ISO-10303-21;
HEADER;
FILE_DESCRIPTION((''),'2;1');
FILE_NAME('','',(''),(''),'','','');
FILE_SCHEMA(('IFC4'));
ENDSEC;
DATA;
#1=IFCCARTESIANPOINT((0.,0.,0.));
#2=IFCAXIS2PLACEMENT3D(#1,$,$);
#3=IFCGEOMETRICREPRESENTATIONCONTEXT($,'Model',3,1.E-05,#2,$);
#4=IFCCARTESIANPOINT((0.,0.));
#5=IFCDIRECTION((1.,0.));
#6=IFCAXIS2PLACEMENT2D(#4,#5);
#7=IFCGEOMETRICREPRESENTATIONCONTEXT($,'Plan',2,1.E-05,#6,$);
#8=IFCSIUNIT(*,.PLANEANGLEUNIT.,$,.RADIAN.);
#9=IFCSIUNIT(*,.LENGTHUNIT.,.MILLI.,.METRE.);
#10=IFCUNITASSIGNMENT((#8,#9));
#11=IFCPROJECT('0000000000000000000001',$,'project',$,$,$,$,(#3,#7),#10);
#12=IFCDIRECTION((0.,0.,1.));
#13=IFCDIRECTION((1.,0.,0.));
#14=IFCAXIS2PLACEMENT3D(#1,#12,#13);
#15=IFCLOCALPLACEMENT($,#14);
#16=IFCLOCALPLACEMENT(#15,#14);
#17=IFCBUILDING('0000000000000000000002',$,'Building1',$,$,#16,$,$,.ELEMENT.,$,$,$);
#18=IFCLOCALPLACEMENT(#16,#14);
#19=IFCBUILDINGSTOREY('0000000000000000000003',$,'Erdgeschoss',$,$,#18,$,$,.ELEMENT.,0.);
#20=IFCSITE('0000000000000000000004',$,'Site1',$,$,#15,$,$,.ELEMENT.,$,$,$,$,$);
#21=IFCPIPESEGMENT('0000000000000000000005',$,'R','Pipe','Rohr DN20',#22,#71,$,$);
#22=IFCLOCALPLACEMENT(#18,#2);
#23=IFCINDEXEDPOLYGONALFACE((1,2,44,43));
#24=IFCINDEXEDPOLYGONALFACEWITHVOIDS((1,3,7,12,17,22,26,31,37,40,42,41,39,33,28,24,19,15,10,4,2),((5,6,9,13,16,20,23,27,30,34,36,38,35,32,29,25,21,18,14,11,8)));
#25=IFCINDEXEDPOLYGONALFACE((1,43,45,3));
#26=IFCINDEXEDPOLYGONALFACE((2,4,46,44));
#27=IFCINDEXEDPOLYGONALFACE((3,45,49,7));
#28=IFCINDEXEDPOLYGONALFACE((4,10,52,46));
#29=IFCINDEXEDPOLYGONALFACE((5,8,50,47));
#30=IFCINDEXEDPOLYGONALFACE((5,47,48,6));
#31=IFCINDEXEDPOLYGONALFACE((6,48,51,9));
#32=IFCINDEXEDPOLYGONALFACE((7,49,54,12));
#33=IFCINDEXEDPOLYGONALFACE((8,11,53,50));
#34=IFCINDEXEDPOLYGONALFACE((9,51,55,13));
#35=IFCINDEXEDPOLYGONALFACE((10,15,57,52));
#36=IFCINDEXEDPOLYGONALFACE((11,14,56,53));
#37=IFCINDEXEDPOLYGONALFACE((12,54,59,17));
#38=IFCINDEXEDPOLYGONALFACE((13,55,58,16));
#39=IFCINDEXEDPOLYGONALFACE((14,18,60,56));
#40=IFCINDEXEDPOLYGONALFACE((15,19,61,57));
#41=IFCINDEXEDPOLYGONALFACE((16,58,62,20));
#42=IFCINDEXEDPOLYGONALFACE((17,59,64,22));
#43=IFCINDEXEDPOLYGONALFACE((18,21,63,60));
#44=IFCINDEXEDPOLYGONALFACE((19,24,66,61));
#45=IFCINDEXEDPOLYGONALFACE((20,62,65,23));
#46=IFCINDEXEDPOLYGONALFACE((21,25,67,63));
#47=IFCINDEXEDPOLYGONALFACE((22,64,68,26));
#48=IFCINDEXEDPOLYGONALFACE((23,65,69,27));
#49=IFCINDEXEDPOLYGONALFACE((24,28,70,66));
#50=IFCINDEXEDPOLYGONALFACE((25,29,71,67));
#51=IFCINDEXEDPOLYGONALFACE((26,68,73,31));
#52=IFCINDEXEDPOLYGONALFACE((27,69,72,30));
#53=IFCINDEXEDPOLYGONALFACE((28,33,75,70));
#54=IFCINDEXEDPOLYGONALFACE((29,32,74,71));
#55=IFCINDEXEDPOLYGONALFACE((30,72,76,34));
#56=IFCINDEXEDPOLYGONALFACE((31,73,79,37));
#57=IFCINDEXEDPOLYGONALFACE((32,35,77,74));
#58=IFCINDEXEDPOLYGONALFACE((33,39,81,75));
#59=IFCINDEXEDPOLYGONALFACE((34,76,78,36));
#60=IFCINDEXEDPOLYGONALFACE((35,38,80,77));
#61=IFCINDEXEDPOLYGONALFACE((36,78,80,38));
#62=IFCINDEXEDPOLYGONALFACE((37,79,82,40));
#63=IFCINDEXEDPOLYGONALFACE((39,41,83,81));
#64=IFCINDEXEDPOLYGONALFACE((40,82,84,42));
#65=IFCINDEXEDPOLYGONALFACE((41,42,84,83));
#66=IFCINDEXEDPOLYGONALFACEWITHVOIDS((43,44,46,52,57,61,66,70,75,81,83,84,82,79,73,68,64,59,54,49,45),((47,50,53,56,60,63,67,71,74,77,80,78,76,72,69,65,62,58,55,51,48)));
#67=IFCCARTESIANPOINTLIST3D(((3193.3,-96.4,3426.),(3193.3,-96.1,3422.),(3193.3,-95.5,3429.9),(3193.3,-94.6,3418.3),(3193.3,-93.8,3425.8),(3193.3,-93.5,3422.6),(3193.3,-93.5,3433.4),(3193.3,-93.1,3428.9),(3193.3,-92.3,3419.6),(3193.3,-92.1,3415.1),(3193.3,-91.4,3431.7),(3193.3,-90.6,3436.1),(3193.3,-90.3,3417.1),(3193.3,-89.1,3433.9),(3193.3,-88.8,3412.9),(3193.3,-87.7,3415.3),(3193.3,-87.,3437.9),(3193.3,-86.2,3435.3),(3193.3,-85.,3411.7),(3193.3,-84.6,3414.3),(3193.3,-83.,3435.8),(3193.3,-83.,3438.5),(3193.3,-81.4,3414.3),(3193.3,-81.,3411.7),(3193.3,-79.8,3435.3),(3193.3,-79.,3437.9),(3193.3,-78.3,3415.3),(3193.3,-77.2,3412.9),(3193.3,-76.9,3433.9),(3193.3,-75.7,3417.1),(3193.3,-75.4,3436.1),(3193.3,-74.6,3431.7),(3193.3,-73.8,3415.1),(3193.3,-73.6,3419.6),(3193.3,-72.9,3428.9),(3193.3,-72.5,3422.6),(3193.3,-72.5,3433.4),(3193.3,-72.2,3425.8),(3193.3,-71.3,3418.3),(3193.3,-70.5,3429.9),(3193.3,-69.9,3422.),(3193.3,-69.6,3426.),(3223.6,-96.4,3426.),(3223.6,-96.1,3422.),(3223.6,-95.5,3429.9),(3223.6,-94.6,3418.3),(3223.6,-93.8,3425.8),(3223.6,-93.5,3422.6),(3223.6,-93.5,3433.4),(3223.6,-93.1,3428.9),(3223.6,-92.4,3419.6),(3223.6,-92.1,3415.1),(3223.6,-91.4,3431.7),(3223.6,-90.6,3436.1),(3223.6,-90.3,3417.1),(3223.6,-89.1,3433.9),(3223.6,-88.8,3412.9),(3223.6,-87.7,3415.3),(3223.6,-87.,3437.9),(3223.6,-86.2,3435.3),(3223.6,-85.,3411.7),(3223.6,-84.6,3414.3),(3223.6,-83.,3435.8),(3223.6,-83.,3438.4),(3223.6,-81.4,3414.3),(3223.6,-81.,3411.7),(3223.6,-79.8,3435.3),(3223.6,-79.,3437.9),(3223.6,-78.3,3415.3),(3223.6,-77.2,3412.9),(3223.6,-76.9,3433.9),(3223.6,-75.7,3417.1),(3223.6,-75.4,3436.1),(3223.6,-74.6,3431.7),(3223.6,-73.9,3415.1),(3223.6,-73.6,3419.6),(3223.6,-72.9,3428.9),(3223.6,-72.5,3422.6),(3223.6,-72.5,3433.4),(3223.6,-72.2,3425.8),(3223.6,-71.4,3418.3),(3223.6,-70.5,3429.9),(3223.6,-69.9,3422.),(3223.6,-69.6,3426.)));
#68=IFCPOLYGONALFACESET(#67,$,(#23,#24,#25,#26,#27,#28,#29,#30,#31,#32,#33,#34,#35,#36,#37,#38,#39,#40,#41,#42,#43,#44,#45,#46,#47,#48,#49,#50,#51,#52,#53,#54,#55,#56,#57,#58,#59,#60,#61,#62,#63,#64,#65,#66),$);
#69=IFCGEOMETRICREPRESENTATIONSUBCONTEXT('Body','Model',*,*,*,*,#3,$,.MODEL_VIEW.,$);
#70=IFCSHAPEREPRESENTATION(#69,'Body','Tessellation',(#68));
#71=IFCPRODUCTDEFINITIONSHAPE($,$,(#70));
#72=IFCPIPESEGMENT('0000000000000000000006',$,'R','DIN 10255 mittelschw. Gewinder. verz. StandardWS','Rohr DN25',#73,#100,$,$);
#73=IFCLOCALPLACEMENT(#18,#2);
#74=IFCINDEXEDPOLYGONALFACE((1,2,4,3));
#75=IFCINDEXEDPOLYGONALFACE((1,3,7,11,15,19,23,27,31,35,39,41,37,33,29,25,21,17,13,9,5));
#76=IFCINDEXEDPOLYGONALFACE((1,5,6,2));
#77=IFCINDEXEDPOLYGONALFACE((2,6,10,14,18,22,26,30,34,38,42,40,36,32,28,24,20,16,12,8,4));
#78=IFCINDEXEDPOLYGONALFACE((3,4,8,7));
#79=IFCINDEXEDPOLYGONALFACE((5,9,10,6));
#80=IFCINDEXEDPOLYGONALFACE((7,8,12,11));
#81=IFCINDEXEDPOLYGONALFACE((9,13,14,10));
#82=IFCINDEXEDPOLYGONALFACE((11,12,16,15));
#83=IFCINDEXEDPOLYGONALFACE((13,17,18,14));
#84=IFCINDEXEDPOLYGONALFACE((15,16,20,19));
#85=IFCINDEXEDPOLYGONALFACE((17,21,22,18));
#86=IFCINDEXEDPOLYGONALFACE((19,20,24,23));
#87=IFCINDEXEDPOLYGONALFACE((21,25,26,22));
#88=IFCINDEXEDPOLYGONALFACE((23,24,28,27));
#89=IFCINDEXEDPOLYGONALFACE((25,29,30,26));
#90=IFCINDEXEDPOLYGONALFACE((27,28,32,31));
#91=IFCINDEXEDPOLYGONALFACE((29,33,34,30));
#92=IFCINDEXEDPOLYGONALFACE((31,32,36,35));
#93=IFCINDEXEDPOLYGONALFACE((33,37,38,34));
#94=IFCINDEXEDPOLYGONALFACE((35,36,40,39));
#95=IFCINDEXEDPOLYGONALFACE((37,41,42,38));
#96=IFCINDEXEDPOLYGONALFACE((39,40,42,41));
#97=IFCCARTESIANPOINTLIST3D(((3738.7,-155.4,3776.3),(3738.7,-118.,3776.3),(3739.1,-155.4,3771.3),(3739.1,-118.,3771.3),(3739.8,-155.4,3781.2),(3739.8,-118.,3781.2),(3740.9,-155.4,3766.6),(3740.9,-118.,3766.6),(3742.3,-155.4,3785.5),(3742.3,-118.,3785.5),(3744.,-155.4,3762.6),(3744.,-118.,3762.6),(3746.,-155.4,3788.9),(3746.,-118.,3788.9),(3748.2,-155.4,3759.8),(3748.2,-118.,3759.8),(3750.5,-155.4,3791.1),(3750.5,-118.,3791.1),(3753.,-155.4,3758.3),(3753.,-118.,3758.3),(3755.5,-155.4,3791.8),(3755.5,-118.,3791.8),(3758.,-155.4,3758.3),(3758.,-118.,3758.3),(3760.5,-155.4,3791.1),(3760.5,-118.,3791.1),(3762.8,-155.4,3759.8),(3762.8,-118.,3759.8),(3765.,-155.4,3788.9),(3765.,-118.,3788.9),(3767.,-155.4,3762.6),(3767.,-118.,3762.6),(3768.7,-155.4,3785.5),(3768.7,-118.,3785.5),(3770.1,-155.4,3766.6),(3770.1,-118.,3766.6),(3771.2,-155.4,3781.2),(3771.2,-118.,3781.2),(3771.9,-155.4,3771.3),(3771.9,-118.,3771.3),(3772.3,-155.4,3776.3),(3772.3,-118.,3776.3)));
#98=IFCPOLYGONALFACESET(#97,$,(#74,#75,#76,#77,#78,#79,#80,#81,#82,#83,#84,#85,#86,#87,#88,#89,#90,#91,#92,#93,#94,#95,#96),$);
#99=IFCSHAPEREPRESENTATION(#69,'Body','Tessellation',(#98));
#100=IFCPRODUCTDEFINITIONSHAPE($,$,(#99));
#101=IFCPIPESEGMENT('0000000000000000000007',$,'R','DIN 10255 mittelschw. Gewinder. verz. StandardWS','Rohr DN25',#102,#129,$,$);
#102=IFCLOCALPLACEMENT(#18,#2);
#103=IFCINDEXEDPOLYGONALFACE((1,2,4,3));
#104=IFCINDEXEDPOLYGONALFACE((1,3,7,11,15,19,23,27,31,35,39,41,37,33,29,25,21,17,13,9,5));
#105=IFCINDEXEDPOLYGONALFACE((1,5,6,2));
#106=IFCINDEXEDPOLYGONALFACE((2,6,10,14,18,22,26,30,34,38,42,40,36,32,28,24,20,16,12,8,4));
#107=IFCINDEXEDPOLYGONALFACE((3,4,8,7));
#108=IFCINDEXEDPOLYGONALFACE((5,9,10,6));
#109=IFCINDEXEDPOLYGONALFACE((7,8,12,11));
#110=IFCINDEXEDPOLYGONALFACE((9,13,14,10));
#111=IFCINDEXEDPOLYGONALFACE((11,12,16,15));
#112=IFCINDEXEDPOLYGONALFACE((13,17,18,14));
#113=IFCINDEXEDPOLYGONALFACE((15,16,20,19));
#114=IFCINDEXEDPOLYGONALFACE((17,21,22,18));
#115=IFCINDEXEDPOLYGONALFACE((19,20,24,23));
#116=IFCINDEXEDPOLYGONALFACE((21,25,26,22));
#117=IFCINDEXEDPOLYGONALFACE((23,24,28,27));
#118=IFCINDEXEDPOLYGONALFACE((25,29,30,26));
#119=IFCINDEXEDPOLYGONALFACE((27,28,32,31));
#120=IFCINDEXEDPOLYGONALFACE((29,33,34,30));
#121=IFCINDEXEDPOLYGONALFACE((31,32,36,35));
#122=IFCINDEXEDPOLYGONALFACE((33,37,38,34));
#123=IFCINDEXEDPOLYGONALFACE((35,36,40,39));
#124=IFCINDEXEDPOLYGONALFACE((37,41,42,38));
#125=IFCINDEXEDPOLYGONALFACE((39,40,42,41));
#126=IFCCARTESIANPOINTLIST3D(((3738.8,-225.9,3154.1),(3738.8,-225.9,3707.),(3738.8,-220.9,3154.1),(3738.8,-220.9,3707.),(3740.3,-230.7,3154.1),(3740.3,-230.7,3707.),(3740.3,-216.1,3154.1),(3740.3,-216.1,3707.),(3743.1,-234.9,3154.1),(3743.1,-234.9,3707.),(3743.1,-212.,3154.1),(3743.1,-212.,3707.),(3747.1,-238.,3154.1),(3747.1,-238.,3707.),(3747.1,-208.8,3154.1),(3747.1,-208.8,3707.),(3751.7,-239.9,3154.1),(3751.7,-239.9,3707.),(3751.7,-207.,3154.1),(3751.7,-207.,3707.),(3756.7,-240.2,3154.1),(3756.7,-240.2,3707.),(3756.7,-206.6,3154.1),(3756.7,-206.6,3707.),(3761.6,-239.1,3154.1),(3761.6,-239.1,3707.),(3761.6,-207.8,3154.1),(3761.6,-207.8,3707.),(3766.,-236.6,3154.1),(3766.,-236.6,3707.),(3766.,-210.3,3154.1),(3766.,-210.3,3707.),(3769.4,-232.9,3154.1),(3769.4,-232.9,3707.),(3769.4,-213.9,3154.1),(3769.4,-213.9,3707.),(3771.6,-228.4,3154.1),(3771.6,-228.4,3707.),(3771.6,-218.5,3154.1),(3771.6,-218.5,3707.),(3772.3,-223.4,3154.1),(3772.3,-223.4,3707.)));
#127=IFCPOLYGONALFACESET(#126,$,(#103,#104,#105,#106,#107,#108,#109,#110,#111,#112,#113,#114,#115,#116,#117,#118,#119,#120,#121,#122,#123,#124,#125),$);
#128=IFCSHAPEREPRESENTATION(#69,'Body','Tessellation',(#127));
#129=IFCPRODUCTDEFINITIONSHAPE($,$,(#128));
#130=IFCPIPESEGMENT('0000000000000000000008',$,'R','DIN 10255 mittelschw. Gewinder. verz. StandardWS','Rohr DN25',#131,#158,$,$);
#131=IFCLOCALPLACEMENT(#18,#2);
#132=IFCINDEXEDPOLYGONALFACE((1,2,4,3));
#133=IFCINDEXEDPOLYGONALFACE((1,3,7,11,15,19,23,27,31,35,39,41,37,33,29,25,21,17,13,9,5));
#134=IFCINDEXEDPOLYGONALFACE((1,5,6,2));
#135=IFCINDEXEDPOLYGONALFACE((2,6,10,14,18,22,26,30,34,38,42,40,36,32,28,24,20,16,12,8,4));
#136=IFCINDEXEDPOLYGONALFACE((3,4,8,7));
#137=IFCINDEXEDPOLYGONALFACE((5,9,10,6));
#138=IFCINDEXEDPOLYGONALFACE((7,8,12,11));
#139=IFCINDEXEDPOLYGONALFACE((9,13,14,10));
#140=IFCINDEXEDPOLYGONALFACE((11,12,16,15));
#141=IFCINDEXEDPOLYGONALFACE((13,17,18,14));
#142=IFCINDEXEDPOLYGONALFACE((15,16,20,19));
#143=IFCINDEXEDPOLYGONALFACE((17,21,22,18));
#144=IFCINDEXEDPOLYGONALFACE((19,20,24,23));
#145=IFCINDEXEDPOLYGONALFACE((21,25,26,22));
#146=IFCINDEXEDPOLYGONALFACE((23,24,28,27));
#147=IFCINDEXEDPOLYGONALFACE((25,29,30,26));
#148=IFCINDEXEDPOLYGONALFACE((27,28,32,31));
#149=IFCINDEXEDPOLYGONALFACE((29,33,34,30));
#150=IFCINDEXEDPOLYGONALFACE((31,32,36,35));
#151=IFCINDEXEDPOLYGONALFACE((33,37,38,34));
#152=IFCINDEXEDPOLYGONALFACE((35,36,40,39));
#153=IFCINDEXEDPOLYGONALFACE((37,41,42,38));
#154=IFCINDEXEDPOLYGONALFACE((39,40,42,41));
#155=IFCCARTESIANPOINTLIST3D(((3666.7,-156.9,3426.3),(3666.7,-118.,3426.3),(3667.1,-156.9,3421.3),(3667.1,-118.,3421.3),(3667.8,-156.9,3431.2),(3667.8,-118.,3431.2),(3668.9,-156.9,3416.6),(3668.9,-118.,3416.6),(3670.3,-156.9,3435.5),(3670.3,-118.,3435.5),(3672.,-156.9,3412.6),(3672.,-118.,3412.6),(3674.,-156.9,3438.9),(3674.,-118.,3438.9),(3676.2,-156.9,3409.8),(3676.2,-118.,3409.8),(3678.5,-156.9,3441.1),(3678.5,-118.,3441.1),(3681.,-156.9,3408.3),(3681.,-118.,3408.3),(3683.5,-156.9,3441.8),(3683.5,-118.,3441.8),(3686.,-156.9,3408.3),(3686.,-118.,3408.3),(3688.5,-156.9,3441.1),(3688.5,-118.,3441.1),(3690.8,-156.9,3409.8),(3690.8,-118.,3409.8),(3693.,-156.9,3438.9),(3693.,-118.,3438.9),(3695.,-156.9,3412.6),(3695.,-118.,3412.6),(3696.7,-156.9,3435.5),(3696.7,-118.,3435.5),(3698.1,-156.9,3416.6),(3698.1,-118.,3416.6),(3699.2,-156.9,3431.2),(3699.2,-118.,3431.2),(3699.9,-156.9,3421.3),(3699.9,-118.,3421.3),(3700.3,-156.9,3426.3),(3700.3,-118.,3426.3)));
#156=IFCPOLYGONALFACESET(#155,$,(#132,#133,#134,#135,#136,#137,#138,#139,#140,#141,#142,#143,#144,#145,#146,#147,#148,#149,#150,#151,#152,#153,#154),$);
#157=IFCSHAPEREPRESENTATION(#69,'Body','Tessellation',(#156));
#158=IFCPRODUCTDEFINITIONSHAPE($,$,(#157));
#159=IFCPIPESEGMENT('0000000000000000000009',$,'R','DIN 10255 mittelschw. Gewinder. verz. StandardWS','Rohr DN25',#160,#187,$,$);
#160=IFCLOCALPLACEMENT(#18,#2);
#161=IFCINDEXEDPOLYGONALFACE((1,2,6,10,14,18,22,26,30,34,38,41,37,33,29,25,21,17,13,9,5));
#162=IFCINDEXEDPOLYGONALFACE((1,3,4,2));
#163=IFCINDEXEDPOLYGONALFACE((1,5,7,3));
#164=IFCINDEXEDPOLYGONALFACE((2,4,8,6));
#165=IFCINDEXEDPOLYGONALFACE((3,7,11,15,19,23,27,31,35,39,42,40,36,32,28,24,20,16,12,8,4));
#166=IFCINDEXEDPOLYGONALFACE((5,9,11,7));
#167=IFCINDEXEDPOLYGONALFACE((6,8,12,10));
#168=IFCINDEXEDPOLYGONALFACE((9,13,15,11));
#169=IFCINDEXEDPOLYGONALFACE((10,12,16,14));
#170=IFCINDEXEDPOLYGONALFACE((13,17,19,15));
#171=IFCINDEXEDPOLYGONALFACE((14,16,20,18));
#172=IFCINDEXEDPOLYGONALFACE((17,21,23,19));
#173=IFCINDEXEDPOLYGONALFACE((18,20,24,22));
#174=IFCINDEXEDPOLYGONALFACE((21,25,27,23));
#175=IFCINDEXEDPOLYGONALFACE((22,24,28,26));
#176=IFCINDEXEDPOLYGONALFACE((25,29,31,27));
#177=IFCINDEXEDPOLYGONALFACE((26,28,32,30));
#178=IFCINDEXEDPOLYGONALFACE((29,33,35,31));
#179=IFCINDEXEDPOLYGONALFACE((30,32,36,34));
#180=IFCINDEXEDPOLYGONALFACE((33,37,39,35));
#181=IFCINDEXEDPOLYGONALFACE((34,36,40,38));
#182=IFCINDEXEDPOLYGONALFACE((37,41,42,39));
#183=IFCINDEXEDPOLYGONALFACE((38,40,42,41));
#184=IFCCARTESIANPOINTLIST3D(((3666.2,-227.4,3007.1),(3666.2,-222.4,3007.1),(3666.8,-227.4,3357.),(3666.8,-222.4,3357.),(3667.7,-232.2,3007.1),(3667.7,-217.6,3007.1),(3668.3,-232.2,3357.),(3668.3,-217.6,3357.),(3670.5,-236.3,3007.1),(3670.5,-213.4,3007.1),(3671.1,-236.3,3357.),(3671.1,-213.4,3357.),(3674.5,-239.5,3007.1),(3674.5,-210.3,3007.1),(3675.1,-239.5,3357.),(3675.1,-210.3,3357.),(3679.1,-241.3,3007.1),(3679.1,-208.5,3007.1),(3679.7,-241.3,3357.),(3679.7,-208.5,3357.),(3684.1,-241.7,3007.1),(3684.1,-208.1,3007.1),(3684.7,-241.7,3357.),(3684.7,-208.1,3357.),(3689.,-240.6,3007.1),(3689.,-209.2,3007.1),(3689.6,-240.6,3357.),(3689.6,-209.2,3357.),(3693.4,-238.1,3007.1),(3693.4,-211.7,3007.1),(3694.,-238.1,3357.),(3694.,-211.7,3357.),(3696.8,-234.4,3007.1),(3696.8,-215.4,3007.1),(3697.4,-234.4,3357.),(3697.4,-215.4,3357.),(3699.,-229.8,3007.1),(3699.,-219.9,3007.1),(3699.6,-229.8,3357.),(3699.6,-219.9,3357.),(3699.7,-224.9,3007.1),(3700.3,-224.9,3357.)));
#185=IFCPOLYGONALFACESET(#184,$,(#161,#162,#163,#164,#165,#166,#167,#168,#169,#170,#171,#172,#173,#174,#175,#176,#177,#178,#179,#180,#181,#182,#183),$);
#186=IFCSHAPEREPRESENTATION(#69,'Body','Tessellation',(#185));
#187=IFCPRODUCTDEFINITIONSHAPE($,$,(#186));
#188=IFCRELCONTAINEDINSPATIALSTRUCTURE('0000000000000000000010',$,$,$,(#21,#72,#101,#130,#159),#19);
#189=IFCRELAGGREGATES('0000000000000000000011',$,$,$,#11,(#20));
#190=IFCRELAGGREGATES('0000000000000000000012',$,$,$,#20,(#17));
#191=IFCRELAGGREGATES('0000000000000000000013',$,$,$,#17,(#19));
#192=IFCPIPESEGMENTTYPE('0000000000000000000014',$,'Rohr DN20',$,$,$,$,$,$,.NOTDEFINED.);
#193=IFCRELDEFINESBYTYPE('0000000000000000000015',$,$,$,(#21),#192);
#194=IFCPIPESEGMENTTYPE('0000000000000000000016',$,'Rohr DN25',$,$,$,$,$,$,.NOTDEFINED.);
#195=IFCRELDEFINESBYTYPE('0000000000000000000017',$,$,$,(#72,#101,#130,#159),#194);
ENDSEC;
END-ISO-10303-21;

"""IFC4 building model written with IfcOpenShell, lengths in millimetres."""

from ifc_helpers import new_model, si_unit, frame, origin, origin_with_axes, origin_2d_with_axis, place, context, subcontext, project, spatial, circle, hollow_circle, extrude, type_object, element, save


model = new_model("IFC4")

# Units and contexts
model_context = context("Model", 3, precision=1e-05, world=origin())
plan_context = context("Plan", 2, precision=1e-05, world=origin_2d_with_axis())
body_context = subcontext(model_context, "Body", "Model", "MODEL_VIEW")
ifc_project = project(units=[si_unit("PLANEANGLEUNIT", "RADIAN"), si_unit("LENGTHUNIT", "METRE", prefix="MILLI")], contexts=[model_context, plan_context])

# Site, building, storey
site_placement = place(None, origin_with_axes())
site = spatial("IfcSite", under=ifc_project, at=site_placement, Name="Site1", CompositionType="ELEMENT")
building_placement = place(site_placement, origin_with_axes())
building = spatial("IfcBuilding", under=site, at=building_placement, Name="Building1", CompositionType="ELEMENT")
storey_placement = place(building_placement, origin_with_axes())
storey = spatial("IfcBuildingStorey", under=building, at=storey_placement, Name="Erdgeschoss", CompositionType="ELEMENT", Elevation=0.0)

# Pipe segments
pipe_segment_type_1 = type_object("IfcPipeSegmentType", Name="Rohr DN20", PredefinedType="NOTDEFINED")
pipe_segment_1_placement = place(storey_placement, frame((3208.4, -82.8, 3425.0), z_axis=(0.0, 0.0, 1.0), x_axis=(1.0, 0.0, 0.0)))
element("IfcPipeSegment", 1, at=pipe_segment_1_placement, inside=storey, type_object=pipe_segment_type_1, Name="R", Description="Pipe", ObjectType="Rohr DN20", context=body_context, shape_type="SolidModel", body=[
    extrude(hollow_circle(Radius=13.4, WallThickness=2.6, at=origin_2d_with_axis()), frame((-15.2, -0.1, 0.0), z_axis=(1.0, -0.000108, -0.000078), x_axis=(0.0, 0.0, 1.0)), (0.0, 0.0, 1.0), 30.3),
])
pipe_segment_type_2 = type_object("IfcPipeSegmentType", Name="Rohr DN25", PredefinedType="NOTDEFINED")
pipe_segment_2_placement = place(storey_placement, frame((3755.6, -136.7, 3775.0), z_axis=(0.0, 0.0, 1.0), x_axis=(1.0, 0.0, 0.0)))
element("IfcPipeSegment", 2, at=pipe_segment_2_placement, inside=storey, type_object=pipe_segment_type_2, Name="R", Description="DIN 10255 mittelschw. Gewinder. verz. StandardWS", ObjectType="Rohr DN25", context=body_context, shape_type="SolidModel", body=[
    extrude(circle(Radius=16.9, at=origin_2d_with_axis()), frame((-0.1, 18.7, 0.0), z_axis=(0.0, -1.0, 0.0), x_axis=(0.0, 0.0, 1.0)), (0.0, 0.0, 1.0), 37.4),
])
pipe_segment_3_placement = place(storey_placement, frame((3755.5, -223.3, 3430.6), z_axis=(0.0, 0.0, 1.0), x_axis=(1.0, 0.0, 0.0)))
element("IfcPipeSegment", 3, at=pipe_segment_3_placement, inside=storey, type_object=pipe_segment_type_2, Name="R", Description="DIN 10255 mittelschw. Gewinder. verz. StandardWS", ObjectType="Rohr DN25", context=body_context, shape_type="SolidModel", body=[
    extrude(circle(Radius=16.9, at=origin_2d_with_axis()), frame((0.0, -0.2, 276.4), z_axis=(0.0, 0.0, -1.0), x_axis=(1.0, 0.0, 0.0)), (0.0, 0.0, 1.0), 552.9),
])
pipe_segment_4_placement = place(storey_placement, frame((3683.6, -137.4, 3425.0), z_axis=(0.0, 0.0, 1.0), x_axis=(1.0, 0.0, 0.0)))
element("IfcPipeSegment", 4, at=pipe_segment_4_placement, inside=storey, type_object=pipe_segment_type_2, Name="R", Description="DIN 10255 mittelschw. Gewinder. verz. StandardWS", ObjectType="Rohr DN25", context=body_context, shape_type="SolidModel", body=[
    extrude(circle(Radius=16.9, at=origin_2d_with_axis()), frame((-0.2, 19.4, 0.0), z_axis=(0.0, -1.0, 0.0), x_axis=(0.0, 0.0, 1.0)), (0.0, 0.0, 1.0), 38.9),
])
pipe_segment_5_placement = place(storey_placement, frame((3683.2, -225.0, 3182.1), z_axis=(0.0, 0.0, 1.0), x_axis=(1.0, 0.0, 0.0)))
element("IfcPipeSegment", 5, at=pipe_segment_5_placement, inside=storey, type_object=pipe_segment_type_2, Name="R", Description="DIN 10255 mittelschw. Gewinder. verz. StandardWS", ObjectType="Rohr DN25", context=body_context, shape_type="SolidModel", body=[
    extrude(circle(Radius=16.9, at=origin_2d_with_axis()), frame((0.3, 0.2, 174.9), z_axis=(-0.00173, 0.0, -0.999999), x_axis=(1.0, 0.0, 0.0)), (0.0, 0.0, 1.0), 349.9),
])

save(model, "model.ifc")
